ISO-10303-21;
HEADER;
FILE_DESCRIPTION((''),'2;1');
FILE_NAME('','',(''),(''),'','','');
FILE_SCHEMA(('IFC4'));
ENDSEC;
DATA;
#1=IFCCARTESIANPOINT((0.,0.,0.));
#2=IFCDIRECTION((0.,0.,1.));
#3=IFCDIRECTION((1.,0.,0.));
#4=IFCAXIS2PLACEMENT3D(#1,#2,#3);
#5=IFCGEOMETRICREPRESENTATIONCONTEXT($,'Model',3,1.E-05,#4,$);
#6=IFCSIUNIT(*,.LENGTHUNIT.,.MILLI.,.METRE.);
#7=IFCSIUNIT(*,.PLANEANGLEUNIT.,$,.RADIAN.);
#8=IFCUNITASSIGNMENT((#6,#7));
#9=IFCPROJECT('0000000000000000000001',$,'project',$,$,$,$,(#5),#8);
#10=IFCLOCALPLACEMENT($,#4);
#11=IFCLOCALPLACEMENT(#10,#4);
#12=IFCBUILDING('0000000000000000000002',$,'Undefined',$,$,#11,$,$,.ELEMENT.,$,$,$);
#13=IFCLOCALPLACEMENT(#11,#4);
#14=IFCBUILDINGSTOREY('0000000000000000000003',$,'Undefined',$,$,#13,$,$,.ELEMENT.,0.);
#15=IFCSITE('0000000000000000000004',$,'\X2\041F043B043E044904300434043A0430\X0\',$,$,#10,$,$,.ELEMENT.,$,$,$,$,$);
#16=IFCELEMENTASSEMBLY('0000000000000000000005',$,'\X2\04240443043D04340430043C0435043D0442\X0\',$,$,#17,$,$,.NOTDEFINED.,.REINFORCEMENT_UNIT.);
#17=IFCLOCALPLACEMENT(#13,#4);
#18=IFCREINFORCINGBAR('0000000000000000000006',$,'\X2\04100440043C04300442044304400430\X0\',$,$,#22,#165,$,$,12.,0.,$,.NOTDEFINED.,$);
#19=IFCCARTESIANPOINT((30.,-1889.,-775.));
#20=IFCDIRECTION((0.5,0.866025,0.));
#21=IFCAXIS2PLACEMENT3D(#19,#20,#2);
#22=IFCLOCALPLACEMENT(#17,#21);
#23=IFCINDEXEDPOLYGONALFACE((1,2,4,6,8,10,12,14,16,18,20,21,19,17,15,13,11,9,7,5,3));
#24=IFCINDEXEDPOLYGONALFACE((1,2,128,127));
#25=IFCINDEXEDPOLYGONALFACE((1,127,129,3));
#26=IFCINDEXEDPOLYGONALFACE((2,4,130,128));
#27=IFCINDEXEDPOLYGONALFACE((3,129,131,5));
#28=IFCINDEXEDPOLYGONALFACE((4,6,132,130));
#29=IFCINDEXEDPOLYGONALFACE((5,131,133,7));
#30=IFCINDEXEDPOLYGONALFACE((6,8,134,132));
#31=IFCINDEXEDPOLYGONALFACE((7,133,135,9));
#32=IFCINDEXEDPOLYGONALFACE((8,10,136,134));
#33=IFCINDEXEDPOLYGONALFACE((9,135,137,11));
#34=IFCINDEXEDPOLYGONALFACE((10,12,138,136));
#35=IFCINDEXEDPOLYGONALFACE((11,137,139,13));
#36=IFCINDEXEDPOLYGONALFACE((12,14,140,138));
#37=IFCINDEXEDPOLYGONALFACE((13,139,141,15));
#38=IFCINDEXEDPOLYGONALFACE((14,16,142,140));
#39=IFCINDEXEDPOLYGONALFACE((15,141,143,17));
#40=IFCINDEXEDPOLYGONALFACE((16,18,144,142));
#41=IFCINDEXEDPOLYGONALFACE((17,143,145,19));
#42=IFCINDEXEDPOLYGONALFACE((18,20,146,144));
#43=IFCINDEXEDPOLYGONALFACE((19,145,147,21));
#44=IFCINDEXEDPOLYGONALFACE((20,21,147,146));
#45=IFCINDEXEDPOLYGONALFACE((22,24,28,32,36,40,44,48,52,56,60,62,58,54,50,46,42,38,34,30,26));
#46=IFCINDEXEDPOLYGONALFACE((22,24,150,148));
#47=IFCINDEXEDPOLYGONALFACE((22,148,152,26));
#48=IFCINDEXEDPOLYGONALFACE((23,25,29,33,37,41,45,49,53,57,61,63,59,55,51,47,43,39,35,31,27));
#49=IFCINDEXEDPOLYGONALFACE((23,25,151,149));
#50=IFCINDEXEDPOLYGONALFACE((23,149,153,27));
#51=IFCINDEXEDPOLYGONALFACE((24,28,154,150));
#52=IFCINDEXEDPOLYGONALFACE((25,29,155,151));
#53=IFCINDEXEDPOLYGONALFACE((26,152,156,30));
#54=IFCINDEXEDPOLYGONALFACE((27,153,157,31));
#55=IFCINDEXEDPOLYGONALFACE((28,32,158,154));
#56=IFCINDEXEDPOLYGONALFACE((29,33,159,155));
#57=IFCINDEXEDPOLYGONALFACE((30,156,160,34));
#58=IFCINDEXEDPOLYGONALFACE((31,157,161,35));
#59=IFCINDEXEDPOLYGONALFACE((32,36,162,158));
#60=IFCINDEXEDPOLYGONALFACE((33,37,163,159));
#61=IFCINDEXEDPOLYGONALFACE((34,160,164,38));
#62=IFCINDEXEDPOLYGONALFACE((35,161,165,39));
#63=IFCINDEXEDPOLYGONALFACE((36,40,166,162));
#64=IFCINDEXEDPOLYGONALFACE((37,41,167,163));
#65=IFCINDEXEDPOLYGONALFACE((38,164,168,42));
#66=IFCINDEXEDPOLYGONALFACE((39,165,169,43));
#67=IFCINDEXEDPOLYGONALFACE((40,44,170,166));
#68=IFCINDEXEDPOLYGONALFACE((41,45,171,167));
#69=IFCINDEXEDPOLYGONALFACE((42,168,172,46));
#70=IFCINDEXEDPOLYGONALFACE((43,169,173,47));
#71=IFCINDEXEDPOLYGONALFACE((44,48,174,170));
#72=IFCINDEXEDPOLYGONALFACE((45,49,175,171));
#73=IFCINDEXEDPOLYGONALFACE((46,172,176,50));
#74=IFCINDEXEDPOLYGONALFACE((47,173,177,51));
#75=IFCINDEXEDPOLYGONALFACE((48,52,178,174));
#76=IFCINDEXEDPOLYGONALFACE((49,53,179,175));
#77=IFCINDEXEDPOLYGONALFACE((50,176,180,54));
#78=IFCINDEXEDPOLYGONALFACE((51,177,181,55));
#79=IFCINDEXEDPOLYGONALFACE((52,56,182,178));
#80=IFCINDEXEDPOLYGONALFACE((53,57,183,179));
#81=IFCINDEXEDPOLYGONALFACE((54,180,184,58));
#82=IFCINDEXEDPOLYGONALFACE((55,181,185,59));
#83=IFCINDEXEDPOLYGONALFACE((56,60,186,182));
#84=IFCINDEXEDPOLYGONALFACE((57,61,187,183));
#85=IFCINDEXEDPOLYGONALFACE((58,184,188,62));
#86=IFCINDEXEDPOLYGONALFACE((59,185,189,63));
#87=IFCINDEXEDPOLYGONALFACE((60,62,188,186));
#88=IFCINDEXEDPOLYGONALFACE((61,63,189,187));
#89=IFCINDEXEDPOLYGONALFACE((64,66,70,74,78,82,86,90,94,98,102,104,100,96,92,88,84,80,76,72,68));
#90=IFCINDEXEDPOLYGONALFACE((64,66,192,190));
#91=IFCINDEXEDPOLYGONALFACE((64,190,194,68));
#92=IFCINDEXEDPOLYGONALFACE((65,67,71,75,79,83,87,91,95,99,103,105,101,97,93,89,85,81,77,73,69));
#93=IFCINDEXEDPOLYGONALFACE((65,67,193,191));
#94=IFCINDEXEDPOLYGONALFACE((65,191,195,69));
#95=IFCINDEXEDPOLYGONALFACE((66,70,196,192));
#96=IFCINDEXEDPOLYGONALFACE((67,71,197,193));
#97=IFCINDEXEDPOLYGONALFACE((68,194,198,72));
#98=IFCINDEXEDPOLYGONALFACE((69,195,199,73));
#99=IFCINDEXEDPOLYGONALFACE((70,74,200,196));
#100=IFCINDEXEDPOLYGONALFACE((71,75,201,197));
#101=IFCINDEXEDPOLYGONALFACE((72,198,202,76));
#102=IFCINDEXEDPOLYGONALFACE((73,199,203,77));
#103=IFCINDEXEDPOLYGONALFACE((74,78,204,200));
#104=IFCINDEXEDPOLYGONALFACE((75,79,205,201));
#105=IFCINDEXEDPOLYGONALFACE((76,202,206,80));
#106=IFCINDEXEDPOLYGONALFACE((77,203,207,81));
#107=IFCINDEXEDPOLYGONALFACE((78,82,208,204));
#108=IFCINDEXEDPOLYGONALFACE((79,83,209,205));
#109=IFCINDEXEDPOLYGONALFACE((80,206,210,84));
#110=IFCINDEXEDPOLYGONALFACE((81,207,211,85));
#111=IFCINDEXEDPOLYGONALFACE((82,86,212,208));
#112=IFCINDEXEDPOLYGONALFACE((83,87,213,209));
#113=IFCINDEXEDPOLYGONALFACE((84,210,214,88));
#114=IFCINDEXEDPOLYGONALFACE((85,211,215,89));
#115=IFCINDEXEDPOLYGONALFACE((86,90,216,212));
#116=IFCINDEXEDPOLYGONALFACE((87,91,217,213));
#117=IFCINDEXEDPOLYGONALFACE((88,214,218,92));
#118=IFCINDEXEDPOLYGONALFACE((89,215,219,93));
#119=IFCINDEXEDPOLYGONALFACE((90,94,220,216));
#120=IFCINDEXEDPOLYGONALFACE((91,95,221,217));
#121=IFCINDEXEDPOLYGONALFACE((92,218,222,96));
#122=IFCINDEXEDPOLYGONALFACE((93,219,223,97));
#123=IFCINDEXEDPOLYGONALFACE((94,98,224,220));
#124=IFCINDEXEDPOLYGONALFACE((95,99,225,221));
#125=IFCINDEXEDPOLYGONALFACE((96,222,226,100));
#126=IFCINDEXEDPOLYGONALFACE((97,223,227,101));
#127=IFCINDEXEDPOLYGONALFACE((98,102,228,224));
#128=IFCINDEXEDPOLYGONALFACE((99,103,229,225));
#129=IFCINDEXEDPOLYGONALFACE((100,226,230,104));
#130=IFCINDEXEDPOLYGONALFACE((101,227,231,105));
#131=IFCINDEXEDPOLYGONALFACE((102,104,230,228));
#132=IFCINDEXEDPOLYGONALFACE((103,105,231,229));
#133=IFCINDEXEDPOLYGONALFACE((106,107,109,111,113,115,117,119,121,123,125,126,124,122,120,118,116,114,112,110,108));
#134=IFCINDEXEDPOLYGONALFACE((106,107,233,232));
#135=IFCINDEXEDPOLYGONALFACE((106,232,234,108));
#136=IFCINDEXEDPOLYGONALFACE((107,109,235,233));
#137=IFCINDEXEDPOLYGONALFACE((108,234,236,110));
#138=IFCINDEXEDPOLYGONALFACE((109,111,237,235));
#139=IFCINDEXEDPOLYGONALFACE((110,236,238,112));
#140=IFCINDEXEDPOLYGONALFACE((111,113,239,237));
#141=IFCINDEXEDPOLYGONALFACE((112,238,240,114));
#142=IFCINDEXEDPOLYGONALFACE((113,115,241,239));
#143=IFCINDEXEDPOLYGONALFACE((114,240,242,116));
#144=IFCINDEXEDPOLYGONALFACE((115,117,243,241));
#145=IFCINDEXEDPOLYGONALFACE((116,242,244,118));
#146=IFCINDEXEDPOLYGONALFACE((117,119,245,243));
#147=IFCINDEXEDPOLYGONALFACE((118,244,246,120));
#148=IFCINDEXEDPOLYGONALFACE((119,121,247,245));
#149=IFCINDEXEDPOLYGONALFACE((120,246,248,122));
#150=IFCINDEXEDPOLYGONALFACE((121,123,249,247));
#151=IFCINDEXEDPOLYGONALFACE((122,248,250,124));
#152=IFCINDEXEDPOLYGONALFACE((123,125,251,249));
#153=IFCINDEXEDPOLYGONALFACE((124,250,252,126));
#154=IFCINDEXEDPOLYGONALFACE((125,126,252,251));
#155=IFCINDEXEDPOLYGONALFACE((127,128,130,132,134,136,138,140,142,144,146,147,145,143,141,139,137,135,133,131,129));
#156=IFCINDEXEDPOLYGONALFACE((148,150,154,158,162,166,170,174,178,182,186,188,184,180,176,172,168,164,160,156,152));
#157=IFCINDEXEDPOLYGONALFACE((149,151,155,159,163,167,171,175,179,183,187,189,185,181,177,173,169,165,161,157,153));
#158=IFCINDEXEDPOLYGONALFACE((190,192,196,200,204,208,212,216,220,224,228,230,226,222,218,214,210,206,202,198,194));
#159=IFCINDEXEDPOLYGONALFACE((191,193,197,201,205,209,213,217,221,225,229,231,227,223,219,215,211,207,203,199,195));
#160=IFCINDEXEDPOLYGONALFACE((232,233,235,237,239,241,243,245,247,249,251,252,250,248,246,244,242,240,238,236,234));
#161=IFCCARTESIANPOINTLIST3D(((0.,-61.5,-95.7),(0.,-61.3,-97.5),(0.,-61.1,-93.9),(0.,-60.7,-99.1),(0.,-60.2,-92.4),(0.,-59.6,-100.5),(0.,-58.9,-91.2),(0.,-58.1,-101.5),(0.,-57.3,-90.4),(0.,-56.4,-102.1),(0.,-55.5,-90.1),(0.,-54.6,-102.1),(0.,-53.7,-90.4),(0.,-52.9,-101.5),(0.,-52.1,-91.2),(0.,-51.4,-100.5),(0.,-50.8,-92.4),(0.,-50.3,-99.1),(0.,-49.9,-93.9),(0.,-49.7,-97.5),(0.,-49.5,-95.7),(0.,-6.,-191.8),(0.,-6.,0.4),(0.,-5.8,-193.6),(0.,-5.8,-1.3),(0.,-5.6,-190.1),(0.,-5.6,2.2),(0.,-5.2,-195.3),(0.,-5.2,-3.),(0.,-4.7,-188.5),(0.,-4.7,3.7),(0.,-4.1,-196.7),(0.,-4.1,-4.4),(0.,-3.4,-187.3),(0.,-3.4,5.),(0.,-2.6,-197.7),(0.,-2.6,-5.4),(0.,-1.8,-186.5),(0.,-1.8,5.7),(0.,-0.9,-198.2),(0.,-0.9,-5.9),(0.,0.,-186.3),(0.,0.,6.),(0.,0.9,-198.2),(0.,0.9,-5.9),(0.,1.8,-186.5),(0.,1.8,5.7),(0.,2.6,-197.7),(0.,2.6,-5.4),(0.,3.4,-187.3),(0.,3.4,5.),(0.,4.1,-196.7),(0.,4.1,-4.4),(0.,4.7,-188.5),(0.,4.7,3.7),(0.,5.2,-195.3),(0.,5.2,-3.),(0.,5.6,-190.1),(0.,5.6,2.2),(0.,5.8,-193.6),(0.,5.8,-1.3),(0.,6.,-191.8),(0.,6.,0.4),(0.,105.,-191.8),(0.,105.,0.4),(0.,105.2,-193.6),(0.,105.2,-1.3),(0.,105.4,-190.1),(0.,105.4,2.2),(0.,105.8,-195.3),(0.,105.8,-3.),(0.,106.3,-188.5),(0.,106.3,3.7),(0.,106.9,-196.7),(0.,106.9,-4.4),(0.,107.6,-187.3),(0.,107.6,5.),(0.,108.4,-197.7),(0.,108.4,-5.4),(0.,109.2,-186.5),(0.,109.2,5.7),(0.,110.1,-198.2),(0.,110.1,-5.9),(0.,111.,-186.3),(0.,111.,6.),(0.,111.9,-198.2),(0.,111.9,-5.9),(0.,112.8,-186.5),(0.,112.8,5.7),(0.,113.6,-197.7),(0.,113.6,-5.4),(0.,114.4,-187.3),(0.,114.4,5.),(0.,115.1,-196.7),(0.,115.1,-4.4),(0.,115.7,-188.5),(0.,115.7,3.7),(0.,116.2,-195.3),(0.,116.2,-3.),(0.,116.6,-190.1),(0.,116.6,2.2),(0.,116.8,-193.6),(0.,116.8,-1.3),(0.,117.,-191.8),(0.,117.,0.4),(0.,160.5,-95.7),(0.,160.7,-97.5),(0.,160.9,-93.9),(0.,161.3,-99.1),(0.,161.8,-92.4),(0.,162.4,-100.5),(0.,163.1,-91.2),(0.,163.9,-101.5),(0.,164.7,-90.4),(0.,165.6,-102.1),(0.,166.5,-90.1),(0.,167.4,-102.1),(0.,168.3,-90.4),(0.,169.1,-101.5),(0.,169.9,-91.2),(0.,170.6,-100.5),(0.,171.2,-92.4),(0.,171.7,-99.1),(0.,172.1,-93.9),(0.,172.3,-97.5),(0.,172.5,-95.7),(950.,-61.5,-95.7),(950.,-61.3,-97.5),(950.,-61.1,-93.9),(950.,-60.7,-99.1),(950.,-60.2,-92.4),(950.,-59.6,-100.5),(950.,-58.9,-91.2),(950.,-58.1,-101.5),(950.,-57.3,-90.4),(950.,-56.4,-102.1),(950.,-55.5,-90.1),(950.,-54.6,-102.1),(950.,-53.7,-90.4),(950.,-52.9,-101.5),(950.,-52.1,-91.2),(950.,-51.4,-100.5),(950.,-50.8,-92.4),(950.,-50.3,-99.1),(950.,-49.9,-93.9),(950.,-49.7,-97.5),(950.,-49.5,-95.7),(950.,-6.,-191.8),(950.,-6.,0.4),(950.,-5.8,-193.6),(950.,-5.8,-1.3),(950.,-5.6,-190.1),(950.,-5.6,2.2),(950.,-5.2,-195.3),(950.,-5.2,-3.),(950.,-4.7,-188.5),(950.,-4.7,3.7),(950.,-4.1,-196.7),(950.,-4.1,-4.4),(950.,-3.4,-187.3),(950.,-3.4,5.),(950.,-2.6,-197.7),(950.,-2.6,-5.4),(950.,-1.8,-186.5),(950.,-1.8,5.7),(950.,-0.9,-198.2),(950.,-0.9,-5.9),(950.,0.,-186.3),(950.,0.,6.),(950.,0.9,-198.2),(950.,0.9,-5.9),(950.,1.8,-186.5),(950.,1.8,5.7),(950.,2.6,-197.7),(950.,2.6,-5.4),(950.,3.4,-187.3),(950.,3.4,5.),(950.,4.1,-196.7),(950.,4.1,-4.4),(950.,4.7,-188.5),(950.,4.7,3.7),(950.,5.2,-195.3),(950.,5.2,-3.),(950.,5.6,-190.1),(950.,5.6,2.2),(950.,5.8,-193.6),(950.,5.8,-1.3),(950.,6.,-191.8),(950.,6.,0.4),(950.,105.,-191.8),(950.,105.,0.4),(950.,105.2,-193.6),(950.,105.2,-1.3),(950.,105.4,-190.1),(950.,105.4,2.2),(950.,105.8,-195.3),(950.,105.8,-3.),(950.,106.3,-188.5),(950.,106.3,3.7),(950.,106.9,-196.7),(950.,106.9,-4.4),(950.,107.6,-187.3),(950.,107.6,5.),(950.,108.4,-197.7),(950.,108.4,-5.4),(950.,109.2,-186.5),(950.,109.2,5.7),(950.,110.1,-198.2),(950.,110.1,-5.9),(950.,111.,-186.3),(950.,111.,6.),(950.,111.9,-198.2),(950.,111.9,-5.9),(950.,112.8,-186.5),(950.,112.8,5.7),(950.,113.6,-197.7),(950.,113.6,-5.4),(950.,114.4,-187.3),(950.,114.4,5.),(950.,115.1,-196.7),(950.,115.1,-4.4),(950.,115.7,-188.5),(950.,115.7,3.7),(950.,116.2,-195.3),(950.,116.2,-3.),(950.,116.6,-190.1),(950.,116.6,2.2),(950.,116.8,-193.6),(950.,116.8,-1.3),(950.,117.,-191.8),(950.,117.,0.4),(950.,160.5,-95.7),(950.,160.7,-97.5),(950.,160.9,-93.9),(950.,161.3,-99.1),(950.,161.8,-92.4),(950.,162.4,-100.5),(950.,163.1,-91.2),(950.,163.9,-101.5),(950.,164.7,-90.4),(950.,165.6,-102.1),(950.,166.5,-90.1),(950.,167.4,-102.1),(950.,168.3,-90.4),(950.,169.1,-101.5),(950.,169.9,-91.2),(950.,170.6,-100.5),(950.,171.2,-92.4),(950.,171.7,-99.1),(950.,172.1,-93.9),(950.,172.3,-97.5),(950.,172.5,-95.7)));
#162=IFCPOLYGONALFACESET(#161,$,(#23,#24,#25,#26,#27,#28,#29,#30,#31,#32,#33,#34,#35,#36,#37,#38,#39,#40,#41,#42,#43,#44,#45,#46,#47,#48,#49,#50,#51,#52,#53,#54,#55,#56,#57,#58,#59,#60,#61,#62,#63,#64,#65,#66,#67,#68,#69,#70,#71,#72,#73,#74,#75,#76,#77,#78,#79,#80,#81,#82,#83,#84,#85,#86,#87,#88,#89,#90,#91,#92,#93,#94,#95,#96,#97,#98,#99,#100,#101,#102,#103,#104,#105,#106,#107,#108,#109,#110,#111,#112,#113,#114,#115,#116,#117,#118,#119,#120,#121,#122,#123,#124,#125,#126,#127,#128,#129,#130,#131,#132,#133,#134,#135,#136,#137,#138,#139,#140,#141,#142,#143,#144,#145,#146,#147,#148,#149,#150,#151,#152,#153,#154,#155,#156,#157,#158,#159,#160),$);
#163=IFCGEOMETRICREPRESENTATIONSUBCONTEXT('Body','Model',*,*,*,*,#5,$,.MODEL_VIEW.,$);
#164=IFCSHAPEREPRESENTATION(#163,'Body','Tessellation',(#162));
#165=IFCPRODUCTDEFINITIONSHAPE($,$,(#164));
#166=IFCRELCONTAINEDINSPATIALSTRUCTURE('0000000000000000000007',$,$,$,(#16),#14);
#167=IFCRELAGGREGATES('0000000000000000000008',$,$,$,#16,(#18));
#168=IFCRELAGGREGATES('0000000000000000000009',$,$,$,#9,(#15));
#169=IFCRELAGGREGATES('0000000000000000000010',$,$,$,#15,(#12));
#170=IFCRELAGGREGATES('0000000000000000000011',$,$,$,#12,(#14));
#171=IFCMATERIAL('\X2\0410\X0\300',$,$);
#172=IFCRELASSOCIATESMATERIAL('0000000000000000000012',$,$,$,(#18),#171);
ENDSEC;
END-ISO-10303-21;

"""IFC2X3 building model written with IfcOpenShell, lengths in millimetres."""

from ifc_helpers import new_model, entity, si_unit, frame, origin_with_axes, place, context, subcontext, project, spatial, source, transform, mapped, material, element, aggregate, save


model = new_model("IFC2X3")

# Units and contexts
model_context = context("Model", 3, precision=1e-05, world=origin_with_axes())
body_context = subcontext(model_context, "Body", "Model", "MODEL_VIEW")
ifc_project = project(units=[si_unit("LENGTHUNIT", "METRE", prefix="MILLI"), si_unit("PLANEANGLEUNIT", "RADIAN")], contexts=[model_context])

# Site, building, storey
site_placement = place(None, origin_with_axes())
site = spatial("IfcSite", under=ifc_project, at=site_placement, Name="Площадка", CompositionType="ELEMENT")
building_placement = place(site_placement, origin_with_axes())
building = spatial("IfcBuilding", under=site, at=building_placement, Name="Undefined", CompositionType="ELEMENT")
storey_placement = place(building_placement, origin_with_axes())
storey = spatial("IfcBuildingStorey", under=building, at=storey_placement, Name="Undefined", CompositionType="ELEMENT", Elevation=0.0)

# Element assembly
assembly_1_placement = place(storey_placement, origin_with_axes())
assembly_1 = element("IfcElementAssembly", 1, at=assembly_1_placement, inside=storey, Name="Фундамент", AssemblyPlace="NOTDEFINED", PredefinedType="REINFORCEMENT_UNIT")

# Reinforcing bar
ifc_material_1 = material(Name="А300")
shared_shape_1 = source(origin_with_axes(), body_context, "Body", "AdvancedSweptSolid", [
    entity("IfcSweptDiskSolid", entity("IfcTrimmedCurve", entity("IfcLine", entity("IfcCartesianPoint", [0.0, 0.0, 0.0]), entity("IfcVector", entity("IfcDirection", [1.0, 0.0, 0.0]), 1.0)), [entity("IfcParameterValue", 0.0)], [entity("IfcParameterValue", 950.0)], True, "PARAMETER"), 6.0, None, 0.0, 950.0),
])
shared_shape_2 = source(origin_with_axes(), body_context, "Body", "AdvancedSweptSolid", [
    entity("IfcSweptDiskSolid", entity("IfcTrimmedCurve", entity("IfcLine", entity("IfcCartesianPoint", [0.0, 0.0, 0.0]), entity("IfcVector", entity("IfcDirection", [1.0, 0.0, 0.0]), 1.0)), [entity("IfcParameterValue", 0.0)], [entity("IfcParameterValue", 950.0)], True, "PARAMETER"), 6.0, None, 0.0, 950.0),
])
shared_shape_3 = source(origin_with_axes(), body_context, "Body", "AdvancedSweptSolid", [
    entity("IfcSweptDiskSolid", entity("IfcTrimmedCurve", entity("IfcLine", entity("IfcCartesianPoint", [0.0, 0.0, 0.0]), entity("IfcVector", entity("IfcDirection", [1.0, 0.0, 0.0]), 1.0)), [entity("IfcParameterValue", 0.0)], [entity("IfcParameterValue", 950.0)], True, "PARAMETER"), 6.0, None, 0.0, 950.0),
])
shared_shape_4 = source(origin_with_axes(), body_context, "Body", "AdvancedSweptSolid", [
    entity("IfcSweptDiskSolid", entity("IfcTrimmedCurve", entity("IfcLine", entity("IfcCartesianPoint", [0.0, 0.0, 0.0]), entity("IfcVector", entity("IfcDirection", [1.0, 0.0, 0.0]), 1.0)), [entity("IfcParameterValue", 0.0)], [entity("IfcParameterValue", 950.0)], True, "PARAMETER"), 6.0, None, 0.0, 950.0),
])
shared_shape_5 = source(origin_with_axes(), body_context, "Body", "AdvancedSweptSolid", [
    entity("IfcSweptDiskSolid", entity("IfcTrimmedCurve", entity("IfcLine", entity("IfcCartesianPoint", [0.0, 0.0, 0.0]), entity("IfcVector", entity("IfcDirection", [1.0, 0.0, 0.0]), 1.0)), [entity("IfcParameterValue", 0.0)], [entity("IfcParameterValue", 950.0)], True, "PARAMETER"), 6.0, None, 0.0, 950.0),
])
shared_shape_6 = source(origin_with_axes(), body_context, "Body", "AdvancedSweptSolid", [
    entity("IfcSweptDiskSolid", entity("IfcTrimmedCurve", entity("IfcLine", entity("IfcCartesianPoint", [0.0, 0.0, 0.0]), entity("IfcVector", entity("IfcDirection", [1.0, 0.0, 0.0]), 1.0)), [entity("IfcParameterValue", 0.0)], [entity("IfcParameterValue", 950.0)], True, "PARAMETER"), 6.0, None, 0.0, 950.0),
])
reinforcing_bar_1_placement = place(assembly_1_placement, frame((30.0, -1889.0, -775.0), z_axis=(0.5, 0.866025, 0.0), x_axis=(0.0, 0.0, 1.0)))
reinforcing_bar_1 = element("IfcReinforcingBar", 2, at=reinforcing_bar_1_placement, material=ifc_material_1, Name="Арматура", BarRole="NOTDEFINED", CrossSectionArea=0.0, NominalDiameter=12.0, context=body_context, shape_type="MappedRepresentation", body=[
    mapped(shared_shape_1, transform((0.0, 0.0, 0.0))),
    mapped(shared_shape_2, transform((0.0, -55.5, -96.1))),
    mapped(shared_shape_3, transform((0.0, 0.0, -192.3))),
    mapped(shared_shape_4, transform((0.0, 111.0, -192.3))),
    mapped(shared_shape_5, transform((0.0, 166.5, -96.1))),
    mapped(shared_shape_6, transform((0.0, 111.0, 0.0))),
])
aggregate(assembly_1, [reinforcing_bar_1])

save(model, "model.ifc")
